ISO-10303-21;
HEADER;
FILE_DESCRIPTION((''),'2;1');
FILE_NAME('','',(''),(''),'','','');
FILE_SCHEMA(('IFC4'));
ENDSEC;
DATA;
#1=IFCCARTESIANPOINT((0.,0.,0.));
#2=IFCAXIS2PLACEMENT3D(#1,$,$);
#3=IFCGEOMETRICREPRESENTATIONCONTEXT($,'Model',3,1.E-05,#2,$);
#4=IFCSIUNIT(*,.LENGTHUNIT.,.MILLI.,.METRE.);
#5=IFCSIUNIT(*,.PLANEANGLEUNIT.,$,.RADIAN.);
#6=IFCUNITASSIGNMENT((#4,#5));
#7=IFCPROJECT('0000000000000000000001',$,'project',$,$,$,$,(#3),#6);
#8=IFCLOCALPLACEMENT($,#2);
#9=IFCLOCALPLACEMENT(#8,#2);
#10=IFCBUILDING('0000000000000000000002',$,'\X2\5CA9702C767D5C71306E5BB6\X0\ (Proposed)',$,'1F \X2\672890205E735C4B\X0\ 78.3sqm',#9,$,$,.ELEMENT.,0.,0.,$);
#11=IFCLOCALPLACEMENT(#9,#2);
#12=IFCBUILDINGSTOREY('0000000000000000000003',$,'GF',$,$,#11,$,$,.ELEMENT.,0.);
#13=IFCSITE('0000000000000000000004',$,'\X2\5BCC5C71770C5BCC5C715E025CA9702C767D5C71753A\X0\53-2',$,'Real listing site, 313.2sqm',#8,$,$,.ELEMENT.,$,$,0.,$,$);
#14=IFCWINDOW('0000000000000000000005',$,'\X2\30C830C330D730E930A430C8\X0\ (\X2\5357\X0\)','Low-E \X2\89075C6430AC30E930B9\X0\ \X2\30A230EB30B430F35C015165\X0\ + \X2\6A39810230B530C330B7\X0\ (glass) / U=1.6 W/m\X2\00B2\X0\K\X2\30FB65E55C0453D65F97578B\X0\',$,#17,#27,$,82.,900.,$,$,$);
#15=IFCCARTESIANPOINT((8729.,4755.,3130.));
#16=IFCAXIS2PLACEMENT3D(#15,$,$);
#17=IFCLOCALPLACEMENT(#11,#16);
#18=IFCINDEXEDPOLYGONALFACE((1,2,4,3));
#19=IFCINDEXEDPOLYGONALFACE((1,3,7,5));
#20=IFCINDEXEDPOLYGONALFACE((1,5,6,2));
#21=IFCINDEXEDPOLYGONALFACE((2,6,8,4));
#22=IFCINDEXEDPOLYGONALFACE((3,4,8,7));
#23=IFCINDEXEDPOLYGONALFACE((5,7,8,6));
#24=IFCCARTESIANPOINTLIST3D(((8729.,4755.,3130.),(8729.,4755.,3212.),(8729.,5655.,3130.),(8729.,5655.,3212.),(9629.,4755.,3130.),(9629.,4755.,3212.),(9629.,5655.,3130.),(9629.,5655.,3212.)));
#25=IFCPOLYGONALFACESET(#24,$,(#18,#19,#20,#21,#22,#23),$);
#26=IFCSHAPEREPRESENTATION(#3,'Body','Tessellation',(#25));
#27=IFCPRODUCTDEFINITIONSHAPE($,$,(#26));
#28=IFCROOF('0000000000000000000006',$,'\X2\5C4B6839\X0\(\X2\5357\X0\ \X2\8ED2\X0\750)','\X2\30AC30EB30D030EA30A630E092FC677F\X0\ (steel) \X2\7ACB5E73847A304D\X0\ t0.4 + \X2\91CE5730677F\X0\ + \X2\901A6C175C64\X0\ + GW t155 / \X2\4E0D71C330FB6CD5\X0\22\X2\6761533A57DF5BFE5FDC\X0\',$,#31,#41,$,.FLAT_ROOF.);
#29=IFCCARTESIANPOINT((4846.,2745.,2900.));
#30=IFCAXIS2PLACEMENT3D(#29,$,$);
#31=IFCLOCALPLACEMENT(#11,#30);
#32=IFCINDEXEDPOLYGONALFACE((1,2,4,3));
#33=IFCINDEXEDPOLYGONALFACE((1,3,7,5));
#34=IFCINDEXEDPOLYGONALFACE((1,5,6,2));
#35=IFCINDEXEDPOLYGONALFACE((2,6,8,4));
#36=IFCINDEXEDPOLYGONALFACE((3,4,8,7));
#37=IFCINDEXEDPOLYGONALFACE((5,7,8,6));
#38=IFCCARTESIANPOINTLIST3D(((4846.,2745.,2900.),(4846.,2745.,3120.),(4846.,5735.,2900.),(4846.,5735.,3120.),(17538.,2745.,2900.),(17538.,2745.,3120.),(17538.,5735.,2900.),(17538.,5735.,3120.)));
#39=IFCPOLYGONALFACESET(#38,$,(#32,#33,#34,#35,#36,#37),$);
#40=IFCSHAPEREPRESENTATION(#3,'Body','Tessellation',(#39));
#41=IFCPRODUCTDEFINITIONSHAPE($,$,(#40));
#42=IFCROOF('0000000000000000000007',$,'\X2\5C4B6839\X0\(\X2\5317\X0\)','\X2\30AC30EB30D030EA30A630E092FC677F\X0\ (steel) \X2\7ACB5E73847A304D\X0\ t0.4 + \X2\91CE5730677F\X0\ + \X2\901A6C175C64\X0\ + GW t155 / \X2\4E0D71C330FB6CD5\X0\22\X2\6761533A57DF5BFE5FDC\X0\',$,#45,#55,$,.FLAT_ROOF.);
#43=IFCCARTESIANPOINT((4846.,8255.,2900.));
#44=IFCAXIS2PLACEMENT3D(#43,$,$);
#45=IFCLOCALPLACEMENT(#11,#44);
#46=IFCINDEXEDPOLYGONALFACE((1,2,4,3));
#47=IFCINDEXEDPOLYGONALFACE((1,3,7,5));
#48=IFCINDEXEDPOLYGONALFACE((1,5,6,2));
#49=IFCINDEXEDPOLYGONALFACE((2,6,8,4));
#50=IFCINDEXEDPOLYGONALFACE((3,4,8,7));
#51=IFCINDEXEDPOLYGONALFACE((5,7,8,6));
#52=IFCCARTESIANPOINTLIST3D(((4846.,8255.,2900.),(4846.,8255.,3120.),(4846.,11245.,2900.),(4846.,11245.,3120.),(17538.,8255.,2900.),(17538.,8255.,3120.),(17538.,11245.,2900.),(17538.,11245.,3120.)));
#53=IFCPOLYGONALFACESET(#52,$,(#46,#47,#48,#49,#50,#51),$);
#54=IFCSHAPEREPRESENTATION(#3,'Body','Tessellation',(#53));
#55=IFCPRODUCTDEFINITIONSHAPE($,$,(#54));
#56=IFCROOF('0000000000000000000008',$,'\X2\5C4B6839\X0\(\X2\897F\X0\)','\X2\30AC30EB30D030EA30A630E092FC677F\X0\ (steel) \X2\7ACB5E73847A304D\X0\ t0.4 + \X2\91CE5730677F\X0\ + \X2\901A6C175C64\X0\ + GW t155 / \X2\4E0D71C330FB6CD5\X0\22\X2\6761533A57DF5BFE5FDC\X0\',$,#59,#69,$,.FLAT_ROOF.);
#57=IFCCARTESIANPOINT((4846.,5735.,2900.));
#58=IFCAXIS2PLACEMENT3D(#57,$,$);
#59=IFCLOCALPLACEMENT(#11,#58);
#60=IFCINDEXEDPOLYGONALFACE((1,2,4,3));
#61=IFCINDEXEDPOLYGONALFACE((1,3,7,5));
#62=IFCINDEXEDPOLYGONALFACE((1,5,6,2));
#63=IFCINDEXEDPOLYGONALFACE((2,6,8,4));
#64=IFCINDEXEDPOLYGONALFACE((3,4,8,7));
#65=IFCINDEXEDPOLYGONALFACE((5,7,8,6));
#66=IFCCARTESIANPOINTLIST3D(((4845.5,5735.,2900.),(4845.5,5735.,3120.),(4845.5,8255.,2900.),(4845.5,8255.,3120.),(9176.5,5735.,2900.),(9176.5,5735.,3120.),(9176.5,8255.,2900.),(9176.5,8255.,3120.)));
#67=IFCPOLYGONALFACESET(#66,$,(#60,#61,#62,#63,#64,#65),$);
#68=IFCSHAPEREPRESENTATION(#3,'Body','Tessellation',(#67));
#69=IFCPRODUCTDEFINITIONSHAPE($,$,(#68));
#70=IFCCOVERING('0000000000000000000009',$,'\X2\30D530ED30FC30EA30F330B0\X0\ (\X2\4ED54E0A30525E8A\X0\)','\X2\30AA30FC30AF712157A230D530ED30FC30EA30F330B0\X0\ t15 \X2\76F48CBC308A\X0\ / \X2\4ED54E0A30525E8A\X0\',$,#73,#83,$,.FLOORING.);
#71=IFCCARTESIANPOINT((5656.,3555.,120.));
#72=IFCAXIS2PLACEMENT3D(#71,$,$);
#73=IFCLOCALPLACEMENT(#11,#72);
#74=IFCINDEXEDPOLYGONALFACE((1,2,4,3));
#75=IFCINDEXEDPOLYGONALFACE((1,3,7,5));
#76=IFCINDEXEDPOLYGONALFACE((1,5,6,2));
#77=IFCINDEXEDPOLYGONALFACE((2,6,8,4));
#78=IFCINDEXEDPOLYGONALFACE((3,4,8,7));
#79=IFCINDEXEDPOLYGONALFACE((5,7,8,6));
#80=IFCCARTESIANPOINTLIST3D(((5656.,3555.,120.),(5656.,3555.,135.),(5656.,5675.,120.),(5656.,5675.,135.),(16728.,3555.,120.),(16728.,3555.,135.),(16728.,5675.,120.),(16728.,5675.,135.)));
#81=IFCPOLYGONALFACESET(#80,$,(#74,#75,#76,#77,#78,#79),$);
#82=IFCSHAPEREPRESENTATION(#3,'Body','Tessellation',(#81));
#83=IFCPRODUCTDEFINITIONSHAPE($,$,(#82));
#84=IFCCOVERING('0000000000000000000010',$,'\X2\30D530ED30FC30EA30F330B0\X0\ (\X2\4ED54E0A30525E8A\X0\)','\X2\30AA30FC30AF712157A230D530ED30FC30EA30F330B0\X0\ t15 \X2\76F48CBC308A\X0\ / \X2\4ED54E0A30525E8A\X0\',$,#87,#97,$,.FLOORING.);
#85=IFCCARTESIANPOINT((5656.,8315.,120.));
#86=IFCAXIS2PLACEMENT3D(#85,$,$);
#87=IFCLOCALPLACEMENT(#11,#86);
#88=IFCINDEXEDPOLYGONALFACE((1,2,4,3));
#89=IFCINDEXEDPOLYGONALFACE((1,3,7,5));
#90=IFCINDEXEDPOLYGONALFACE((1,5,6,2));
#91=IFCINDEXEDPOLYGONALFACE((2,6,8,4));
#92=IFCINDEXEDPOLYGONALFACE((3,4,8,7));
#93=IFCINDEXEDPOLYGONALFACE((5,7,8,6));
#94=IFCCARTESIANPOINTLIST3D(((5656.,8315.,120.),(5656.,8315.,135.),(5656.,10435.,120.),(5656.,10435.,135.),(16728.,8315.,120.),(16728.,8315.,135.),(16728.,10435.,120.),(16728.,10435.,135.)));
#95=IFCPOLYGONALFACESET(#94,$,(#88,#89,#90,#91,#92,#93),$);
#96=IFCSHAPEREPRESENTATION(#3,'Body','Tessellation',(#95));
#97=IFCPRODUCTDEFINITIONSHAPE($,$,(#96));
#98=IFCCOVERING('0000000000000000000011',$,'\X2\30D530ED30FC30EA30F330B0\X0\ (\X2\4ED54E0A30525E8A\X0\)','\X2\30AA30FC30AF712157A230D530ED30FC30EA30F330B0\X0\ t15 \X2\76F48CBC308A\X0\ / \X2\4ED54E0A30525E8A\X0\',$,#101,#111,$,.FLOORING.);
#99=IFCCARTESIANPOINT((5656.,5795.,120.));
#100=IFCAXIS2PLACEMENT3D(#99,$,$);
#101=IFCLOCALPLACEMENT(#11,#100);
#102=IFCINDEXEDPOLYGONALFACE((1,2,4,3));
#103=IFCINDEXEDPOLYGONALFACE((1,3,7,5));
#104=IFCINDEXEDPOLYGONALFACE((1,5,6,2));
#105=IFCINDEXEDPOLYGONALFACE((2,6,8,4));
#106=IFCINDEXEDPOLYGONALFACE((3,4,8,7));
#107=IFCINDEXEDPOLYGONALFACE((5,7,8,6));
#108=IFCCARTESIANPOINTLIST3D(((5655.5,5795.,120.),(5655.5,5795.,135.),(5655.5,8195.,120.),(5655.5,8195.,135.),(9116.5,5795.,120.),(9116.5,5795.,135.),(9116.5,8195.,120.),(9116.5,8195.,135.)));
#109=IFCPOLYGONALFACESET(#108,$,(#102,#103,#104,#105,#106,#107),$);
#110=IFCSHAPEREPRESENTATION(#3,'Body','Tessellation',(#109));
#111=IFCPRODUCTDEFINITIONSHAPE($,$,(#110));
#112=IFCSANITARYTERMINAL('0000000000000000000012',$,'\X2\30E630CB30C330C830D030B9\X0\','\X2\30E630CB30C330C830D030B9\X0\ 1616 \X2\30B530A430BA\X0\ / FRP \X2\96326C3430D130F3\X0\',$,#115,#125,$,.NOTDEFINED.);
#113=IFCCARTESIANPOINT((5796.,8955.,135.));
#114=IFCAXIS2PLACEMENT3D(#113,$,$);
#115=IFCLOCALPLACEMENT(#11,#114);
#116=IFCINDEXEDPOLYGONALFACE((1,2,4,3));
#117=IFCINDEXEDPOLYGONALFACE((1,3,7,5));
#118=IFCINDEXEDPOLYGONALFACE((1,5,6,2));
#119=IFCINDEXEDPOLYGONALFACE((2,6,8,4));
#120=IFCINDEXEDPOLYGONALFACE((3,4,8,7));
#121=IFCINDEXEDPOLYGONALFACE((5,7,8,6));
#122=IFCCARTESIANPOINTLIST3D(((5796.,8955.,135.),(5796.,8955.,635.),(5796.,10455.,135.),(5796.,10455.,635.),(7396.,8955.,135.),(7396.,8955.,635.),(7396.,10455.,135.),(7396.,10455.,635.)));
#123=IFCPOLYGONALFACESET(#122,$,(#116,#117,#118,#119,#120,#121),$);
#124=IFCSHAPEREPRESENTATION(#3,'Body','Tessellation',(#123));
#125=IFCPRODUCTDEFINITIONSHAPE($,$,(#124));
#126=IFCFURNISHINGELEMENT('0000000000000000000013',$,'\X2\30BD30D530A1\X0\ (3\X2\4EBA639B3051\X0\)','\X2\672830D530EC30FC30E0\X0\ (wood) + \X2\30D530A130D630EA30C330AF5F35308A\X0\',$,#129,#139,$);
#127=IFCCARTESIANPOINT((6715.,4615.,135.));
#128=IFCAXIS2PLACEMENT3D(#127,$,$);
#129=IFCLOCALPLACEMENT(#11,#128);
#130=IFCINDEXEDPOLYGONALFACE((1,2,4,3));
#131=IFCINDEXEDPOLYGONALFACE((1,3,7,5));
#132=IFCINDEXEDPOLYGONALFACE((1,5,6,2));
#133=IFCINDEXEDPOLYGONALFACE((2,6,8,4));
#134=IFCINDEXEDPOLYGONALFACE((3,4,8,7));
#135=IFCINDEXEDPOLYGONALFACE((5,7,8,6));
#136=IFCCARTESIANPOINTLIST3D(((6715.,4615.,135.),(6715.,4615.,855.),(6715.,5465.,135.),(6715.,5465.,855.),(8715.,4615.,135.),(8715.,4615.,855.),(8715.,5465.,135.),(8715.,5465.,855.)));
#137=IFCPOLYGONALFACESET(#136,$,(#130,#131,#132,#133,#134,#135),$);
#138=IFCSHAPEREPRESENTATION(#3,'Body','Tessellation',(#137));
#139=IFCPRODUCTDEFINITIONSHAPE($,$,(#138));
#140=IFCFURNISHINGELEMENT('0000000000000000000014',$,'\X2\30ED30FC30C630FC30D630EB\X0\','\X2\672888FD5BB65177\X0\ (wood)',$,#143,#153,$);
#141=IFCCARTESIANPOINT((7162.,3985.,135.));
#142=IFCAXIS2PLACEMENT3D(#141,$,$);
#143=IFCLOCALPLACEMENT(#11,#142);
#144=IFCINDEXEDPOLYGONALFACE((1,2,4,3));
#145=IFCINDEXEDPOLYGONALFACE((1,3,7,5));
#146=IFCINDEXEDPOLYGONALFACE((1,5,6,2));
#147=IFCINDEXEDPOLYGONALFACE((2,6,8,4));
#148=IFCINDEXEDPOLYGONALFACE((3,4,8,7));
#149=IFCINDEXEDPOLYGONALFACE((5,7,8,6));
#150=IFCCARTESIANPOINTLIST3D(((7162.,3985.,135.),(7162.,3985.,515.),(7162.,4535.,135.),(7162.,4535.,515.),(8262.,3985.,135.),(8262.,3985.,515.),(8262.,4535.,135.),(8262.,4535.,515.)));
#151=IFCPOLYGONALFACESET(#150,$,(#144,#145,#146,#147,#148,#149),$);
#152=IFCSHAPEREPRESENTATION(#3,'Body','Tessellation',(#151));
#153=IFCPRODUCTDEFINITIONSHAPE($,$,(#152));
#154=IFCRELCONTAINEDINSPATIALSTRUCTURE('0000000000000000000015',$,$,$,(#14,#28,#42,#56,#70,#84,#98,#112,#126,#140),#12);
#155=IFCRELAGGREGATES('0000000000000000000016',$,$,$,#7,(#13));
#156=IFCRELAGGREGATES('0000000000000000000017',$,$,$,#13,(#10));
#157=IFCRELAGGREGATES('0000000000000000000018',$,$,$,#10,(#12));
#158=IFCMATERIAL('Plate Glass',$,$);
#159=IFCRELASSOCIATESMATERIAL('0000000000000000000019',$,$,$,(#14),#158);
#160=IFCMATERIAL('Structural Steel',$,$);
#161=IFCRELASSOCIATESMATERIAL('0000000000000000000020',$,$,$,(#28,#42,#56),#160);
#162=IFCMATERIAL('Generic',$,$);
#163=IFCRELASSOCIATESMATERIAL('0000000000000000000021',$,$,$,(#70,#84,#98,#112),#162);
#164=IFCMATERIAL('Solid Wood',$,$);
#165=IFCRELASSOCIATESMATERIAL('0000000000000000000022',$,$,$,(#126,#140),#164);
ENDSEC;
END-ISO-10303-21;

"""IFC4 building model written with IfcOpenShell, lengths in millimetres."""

from ifc_helpers import new_model, si_unit, frame, frame_2d, origin, place, context, project, spatial, rectangle, extrude, material, element, save


model = new_model("IFC4")

# Units and contexts
model_context = context("Model", 3, precision=1e-05, world=origin())
ifc_project = project(units=[si_unit("LENGTHUNIT", "METRE", prefix="MILLI"), si_unit("PLANEANGLEUNIT", "RADIAN")], contexts=[model_context])

# Site, building, storey
site_placement = place(None, origin())
site = spatial("IfcSite", under=ifc_project, at=site_placement, Name="富山県富山市岩瀬白山町53-2", ObjectType="Real listing site, 313.2sqm", CompositionType="ELEMENT", RefElevation=0.0)
building_placement = place(site_placement, origin())
building = spatial("IfcBuilding", under=site, at=building_placement, Name="岩瀬白山の家 (Proposed)", ObjectType="1F 木造平屋 78.3sqm", CompositionType="ELEMENT", ElevationOfRefHeight=0.0, ElevationOfTerrain=0.0)
storey_placement = place(building_placement, origin())
storey = spatial("IfcBuildingStorey", under=building, at=storey_placement, Name="GF", CompositionType="ELEMENT", Elevation=0.0)

# Shared definitions
ifc_material_1 = material(Name="Solid Wood")

# Shared definitions
ifc_material_2 = material(Name="Plate Glass")

# Window
window_1_placement = place(storey_placement, frame((8729.0, 4755.0, 3130.0)))
element("IfcWindow", 1, at=window_1_placement, inside=storey, material=ifc_material_2, Name="トップライト (南)", Description="Low-E 複層ガラス アルゴン封入 + 樹脂サッシ (glass) / U=1.6 W/m²K・日射取得型", OverallHeight=82.0, OverallWidth=900.0, context=model_context, shape_type="SweptSolid", body=[
    extrude(rectangle(XDim=900.0, YDim=900.0, at=frame_2d((450.0, 450.0))), frame((8729.0, 4755.0, 3130.0)), (0.0, 0.0, 1.0), 82.0),
])

# Roofs
ifc_material_3 = material(Name="Structural Steel")
roof_1_placement = place(storey_placement, frame((4846.0, 2745.0, 2900.0)))
element("IfcRoof", 2, at=roof_1_placement, inside=storey, material=ifc_material_3, Name="屋根(南 軒750)", Description="ガルバリウム鋼板 (steel) 立平葺き t0.4 + 野地板 + 通気層 + GW t155 / 不燃・法22条区域対応", PredefinedType="FLAT_ROOF", context=model_context, shape_type="SweptSolid", body=[
    extrude(rectangle(XDim=12692.0, YDim=2990.0, at=frame_2d((6346.0, 1495.0))), frame((4846.0, 2745.0, 2900.0)), (0.0, 0.0, 1.0), 220.0),
])
roof_2_placement = place(storey_placement, frame((4846.0, 8255.0, 2900.0)))
element("IfcRoof", 3, at=roof_2_placement, inside=storey, material=ifc_material_3, Name="屋根(北)", Description="ガルバリウム鋼板 (steel) 立平葺き t0.4 + 野地板 + 通気層 + GW t155 / 不燃・法22条区域対応", PredefinedType="FLAT_ROOF", context=model_context, shape_type="SweptSolid", body=[
    extrude(rectangle(XDim=12692.0, YDim=2990.0, at=frame_2d((6346.0, 1495.0))), frame((4846.0, 8255.0, 2900.0)), (0.0, 0.0, 1.0), 220.0),
])
roof_3_placement = place(storey_placement, frame((4846.0, 5735.0, 2900.0)))
element("IfcRoof", 4, at=roof_3_placement, inside=storey, material=ifc_material_3, Name="屋根(西)", Description="ガルバリウム鋼板 (steel) 立平葺き t0.4 + 野地板 + 通気層 + GW t155 / 不燃・法22条区域対応", PredefinedType="FLAT_ROOF", context=model_context, shape_type="SweptSolid", body=[
    extrude(rectangle(XDim=4331.0, YDim=2520.0, at=frame_2d((2165.0, 1260.0))), frame((4846.0, 5735.0, 2900.0)), (0.0, 0.0, 1.0), 220.0),
])

# Coverings
ifc_material_4 = material(Name="Generic")
covering_1_placement = place(storey_placement, frame((5656.0, 3555.0, 120.0)))
element("IfcCovering", 5, at=covering_1_placement, inside=storey, material=ifc_material_4, Name="フローリング (仕上げ床)", Description="オーク無垢フローリング t15 直貼り / 仕上げ床", PredefinedType="FLOORING", context=model_context, shape_type="SweptSolid", body=[
    extrude(rectangle(XDim=11072.0, YDim=2120.0, at=frame_2d((5536.0, 1060.0))), frame((5656.0, 3555.0, 120.0)), (0.0, 0.0, 1.0), 15.0),
])
covering_2_placement = place(storey_placement, frame((5656.0, 8315.0, 120.0)))
element("IfcCovering", 6, at=covering_2_placement, inside=storey, material=ifc_material_4, Name="フローリング (仕上げ床)", Description="オーク無垢フローリング t15 直貼り / 仕上げ床", PredefinedType="FLOORING", context=model_context, shape_type="SweptSolid", body=[
    extrude(rectangle(XDim=11072.0, YDim=2120.0, at=frame_2d((5536.0, 1060.0))), frame((5656.0, 8315.0, 120.0)), (0.0, 0.0, 1.0), 15.0),
])
covering_3_placement = place(storey_placement, frame((5656.0, 5795.0, 120.0)))
element("IfcCovering", 7, at=covering_3_placement, inside=storey, material=ifc_material_4, Name="フローリング (仕上げ床)", Description="オーク無垢フローリング t15 直貼り / 仕上げ床", PredefinedType="FLOORING", context=model_context, shape_type="SweptSolid", body=[
    extrude(rectangle(XDim=3461.0, YDim=2400.0, at=frame_2d((1730.0, 1200.0))), frame((5656.0, 5795.0, 120.0)), (0.0, 0.0, 1.0), 15.0),
])

# Sanitary terminal
sanitary_terminal_placement = place(storey_placement, frame((5796.0, 8955.0, 135.0)))
element("IfcSanitaryTerminal", 8, at=sanitary_terminal_placement, inside=storey, material=ifc_material_4, Name="ユニットバス", Description="ユニットバス 1616 サイズ / FRP 防水パン", PredefinedType="NOTDEFINED", context=model_context, shape_type="SweptSolid", body=[
    extrude(rectangle(XDim=1600.0, YDim=1500.0, at=frame_2d((800.0, 750.0))), frame((5796.0, 8955.0, 135.0)), (0.0, 0.0, 1.0), 500.0),
])

# Furnishing elements
furnishing_1_placement = place(storey_placement, frame((6715.0, 4615.0, 135.0)))
element("IfcFurnishingElement", 9, at=furnishing_1_placement, inside=storey, material=ifc_material_1, Name="ソファ (3人掛け)", Description="木フレーム (wood) + ファブリック張り", context=model_context, shape_type="SweptSolid", body=[
    extrude(rectangle(XDim=2000.0, YDim=850.0, at=frame_2d((1000.0, 425.0))), frame((6715.0, 4615.0, 135.0)), (0.0, 0.0, 1.0), 720.0),
])
furnishing_2_placement = place(storey_placement, frame((7162.0, 3985.0, 135.0)))
element("IfcFurnishingElement", 10, at=furnishing_2_placement, inside=storey, material=ifc_material_1, Name="ローテーブル", Description="木製家具 (wood)", context=model_context, shape_type="SweptSolid", body=[
    extrude(rectangle(XDim=1100.0, YDim=550.0, at=frame_2d((550.0, 275.0))), frame((7162.0, 3985.0, 135.0)), (0.0, 0.0, 1.0), 380.0),
])

save(model, "model.ifc")
